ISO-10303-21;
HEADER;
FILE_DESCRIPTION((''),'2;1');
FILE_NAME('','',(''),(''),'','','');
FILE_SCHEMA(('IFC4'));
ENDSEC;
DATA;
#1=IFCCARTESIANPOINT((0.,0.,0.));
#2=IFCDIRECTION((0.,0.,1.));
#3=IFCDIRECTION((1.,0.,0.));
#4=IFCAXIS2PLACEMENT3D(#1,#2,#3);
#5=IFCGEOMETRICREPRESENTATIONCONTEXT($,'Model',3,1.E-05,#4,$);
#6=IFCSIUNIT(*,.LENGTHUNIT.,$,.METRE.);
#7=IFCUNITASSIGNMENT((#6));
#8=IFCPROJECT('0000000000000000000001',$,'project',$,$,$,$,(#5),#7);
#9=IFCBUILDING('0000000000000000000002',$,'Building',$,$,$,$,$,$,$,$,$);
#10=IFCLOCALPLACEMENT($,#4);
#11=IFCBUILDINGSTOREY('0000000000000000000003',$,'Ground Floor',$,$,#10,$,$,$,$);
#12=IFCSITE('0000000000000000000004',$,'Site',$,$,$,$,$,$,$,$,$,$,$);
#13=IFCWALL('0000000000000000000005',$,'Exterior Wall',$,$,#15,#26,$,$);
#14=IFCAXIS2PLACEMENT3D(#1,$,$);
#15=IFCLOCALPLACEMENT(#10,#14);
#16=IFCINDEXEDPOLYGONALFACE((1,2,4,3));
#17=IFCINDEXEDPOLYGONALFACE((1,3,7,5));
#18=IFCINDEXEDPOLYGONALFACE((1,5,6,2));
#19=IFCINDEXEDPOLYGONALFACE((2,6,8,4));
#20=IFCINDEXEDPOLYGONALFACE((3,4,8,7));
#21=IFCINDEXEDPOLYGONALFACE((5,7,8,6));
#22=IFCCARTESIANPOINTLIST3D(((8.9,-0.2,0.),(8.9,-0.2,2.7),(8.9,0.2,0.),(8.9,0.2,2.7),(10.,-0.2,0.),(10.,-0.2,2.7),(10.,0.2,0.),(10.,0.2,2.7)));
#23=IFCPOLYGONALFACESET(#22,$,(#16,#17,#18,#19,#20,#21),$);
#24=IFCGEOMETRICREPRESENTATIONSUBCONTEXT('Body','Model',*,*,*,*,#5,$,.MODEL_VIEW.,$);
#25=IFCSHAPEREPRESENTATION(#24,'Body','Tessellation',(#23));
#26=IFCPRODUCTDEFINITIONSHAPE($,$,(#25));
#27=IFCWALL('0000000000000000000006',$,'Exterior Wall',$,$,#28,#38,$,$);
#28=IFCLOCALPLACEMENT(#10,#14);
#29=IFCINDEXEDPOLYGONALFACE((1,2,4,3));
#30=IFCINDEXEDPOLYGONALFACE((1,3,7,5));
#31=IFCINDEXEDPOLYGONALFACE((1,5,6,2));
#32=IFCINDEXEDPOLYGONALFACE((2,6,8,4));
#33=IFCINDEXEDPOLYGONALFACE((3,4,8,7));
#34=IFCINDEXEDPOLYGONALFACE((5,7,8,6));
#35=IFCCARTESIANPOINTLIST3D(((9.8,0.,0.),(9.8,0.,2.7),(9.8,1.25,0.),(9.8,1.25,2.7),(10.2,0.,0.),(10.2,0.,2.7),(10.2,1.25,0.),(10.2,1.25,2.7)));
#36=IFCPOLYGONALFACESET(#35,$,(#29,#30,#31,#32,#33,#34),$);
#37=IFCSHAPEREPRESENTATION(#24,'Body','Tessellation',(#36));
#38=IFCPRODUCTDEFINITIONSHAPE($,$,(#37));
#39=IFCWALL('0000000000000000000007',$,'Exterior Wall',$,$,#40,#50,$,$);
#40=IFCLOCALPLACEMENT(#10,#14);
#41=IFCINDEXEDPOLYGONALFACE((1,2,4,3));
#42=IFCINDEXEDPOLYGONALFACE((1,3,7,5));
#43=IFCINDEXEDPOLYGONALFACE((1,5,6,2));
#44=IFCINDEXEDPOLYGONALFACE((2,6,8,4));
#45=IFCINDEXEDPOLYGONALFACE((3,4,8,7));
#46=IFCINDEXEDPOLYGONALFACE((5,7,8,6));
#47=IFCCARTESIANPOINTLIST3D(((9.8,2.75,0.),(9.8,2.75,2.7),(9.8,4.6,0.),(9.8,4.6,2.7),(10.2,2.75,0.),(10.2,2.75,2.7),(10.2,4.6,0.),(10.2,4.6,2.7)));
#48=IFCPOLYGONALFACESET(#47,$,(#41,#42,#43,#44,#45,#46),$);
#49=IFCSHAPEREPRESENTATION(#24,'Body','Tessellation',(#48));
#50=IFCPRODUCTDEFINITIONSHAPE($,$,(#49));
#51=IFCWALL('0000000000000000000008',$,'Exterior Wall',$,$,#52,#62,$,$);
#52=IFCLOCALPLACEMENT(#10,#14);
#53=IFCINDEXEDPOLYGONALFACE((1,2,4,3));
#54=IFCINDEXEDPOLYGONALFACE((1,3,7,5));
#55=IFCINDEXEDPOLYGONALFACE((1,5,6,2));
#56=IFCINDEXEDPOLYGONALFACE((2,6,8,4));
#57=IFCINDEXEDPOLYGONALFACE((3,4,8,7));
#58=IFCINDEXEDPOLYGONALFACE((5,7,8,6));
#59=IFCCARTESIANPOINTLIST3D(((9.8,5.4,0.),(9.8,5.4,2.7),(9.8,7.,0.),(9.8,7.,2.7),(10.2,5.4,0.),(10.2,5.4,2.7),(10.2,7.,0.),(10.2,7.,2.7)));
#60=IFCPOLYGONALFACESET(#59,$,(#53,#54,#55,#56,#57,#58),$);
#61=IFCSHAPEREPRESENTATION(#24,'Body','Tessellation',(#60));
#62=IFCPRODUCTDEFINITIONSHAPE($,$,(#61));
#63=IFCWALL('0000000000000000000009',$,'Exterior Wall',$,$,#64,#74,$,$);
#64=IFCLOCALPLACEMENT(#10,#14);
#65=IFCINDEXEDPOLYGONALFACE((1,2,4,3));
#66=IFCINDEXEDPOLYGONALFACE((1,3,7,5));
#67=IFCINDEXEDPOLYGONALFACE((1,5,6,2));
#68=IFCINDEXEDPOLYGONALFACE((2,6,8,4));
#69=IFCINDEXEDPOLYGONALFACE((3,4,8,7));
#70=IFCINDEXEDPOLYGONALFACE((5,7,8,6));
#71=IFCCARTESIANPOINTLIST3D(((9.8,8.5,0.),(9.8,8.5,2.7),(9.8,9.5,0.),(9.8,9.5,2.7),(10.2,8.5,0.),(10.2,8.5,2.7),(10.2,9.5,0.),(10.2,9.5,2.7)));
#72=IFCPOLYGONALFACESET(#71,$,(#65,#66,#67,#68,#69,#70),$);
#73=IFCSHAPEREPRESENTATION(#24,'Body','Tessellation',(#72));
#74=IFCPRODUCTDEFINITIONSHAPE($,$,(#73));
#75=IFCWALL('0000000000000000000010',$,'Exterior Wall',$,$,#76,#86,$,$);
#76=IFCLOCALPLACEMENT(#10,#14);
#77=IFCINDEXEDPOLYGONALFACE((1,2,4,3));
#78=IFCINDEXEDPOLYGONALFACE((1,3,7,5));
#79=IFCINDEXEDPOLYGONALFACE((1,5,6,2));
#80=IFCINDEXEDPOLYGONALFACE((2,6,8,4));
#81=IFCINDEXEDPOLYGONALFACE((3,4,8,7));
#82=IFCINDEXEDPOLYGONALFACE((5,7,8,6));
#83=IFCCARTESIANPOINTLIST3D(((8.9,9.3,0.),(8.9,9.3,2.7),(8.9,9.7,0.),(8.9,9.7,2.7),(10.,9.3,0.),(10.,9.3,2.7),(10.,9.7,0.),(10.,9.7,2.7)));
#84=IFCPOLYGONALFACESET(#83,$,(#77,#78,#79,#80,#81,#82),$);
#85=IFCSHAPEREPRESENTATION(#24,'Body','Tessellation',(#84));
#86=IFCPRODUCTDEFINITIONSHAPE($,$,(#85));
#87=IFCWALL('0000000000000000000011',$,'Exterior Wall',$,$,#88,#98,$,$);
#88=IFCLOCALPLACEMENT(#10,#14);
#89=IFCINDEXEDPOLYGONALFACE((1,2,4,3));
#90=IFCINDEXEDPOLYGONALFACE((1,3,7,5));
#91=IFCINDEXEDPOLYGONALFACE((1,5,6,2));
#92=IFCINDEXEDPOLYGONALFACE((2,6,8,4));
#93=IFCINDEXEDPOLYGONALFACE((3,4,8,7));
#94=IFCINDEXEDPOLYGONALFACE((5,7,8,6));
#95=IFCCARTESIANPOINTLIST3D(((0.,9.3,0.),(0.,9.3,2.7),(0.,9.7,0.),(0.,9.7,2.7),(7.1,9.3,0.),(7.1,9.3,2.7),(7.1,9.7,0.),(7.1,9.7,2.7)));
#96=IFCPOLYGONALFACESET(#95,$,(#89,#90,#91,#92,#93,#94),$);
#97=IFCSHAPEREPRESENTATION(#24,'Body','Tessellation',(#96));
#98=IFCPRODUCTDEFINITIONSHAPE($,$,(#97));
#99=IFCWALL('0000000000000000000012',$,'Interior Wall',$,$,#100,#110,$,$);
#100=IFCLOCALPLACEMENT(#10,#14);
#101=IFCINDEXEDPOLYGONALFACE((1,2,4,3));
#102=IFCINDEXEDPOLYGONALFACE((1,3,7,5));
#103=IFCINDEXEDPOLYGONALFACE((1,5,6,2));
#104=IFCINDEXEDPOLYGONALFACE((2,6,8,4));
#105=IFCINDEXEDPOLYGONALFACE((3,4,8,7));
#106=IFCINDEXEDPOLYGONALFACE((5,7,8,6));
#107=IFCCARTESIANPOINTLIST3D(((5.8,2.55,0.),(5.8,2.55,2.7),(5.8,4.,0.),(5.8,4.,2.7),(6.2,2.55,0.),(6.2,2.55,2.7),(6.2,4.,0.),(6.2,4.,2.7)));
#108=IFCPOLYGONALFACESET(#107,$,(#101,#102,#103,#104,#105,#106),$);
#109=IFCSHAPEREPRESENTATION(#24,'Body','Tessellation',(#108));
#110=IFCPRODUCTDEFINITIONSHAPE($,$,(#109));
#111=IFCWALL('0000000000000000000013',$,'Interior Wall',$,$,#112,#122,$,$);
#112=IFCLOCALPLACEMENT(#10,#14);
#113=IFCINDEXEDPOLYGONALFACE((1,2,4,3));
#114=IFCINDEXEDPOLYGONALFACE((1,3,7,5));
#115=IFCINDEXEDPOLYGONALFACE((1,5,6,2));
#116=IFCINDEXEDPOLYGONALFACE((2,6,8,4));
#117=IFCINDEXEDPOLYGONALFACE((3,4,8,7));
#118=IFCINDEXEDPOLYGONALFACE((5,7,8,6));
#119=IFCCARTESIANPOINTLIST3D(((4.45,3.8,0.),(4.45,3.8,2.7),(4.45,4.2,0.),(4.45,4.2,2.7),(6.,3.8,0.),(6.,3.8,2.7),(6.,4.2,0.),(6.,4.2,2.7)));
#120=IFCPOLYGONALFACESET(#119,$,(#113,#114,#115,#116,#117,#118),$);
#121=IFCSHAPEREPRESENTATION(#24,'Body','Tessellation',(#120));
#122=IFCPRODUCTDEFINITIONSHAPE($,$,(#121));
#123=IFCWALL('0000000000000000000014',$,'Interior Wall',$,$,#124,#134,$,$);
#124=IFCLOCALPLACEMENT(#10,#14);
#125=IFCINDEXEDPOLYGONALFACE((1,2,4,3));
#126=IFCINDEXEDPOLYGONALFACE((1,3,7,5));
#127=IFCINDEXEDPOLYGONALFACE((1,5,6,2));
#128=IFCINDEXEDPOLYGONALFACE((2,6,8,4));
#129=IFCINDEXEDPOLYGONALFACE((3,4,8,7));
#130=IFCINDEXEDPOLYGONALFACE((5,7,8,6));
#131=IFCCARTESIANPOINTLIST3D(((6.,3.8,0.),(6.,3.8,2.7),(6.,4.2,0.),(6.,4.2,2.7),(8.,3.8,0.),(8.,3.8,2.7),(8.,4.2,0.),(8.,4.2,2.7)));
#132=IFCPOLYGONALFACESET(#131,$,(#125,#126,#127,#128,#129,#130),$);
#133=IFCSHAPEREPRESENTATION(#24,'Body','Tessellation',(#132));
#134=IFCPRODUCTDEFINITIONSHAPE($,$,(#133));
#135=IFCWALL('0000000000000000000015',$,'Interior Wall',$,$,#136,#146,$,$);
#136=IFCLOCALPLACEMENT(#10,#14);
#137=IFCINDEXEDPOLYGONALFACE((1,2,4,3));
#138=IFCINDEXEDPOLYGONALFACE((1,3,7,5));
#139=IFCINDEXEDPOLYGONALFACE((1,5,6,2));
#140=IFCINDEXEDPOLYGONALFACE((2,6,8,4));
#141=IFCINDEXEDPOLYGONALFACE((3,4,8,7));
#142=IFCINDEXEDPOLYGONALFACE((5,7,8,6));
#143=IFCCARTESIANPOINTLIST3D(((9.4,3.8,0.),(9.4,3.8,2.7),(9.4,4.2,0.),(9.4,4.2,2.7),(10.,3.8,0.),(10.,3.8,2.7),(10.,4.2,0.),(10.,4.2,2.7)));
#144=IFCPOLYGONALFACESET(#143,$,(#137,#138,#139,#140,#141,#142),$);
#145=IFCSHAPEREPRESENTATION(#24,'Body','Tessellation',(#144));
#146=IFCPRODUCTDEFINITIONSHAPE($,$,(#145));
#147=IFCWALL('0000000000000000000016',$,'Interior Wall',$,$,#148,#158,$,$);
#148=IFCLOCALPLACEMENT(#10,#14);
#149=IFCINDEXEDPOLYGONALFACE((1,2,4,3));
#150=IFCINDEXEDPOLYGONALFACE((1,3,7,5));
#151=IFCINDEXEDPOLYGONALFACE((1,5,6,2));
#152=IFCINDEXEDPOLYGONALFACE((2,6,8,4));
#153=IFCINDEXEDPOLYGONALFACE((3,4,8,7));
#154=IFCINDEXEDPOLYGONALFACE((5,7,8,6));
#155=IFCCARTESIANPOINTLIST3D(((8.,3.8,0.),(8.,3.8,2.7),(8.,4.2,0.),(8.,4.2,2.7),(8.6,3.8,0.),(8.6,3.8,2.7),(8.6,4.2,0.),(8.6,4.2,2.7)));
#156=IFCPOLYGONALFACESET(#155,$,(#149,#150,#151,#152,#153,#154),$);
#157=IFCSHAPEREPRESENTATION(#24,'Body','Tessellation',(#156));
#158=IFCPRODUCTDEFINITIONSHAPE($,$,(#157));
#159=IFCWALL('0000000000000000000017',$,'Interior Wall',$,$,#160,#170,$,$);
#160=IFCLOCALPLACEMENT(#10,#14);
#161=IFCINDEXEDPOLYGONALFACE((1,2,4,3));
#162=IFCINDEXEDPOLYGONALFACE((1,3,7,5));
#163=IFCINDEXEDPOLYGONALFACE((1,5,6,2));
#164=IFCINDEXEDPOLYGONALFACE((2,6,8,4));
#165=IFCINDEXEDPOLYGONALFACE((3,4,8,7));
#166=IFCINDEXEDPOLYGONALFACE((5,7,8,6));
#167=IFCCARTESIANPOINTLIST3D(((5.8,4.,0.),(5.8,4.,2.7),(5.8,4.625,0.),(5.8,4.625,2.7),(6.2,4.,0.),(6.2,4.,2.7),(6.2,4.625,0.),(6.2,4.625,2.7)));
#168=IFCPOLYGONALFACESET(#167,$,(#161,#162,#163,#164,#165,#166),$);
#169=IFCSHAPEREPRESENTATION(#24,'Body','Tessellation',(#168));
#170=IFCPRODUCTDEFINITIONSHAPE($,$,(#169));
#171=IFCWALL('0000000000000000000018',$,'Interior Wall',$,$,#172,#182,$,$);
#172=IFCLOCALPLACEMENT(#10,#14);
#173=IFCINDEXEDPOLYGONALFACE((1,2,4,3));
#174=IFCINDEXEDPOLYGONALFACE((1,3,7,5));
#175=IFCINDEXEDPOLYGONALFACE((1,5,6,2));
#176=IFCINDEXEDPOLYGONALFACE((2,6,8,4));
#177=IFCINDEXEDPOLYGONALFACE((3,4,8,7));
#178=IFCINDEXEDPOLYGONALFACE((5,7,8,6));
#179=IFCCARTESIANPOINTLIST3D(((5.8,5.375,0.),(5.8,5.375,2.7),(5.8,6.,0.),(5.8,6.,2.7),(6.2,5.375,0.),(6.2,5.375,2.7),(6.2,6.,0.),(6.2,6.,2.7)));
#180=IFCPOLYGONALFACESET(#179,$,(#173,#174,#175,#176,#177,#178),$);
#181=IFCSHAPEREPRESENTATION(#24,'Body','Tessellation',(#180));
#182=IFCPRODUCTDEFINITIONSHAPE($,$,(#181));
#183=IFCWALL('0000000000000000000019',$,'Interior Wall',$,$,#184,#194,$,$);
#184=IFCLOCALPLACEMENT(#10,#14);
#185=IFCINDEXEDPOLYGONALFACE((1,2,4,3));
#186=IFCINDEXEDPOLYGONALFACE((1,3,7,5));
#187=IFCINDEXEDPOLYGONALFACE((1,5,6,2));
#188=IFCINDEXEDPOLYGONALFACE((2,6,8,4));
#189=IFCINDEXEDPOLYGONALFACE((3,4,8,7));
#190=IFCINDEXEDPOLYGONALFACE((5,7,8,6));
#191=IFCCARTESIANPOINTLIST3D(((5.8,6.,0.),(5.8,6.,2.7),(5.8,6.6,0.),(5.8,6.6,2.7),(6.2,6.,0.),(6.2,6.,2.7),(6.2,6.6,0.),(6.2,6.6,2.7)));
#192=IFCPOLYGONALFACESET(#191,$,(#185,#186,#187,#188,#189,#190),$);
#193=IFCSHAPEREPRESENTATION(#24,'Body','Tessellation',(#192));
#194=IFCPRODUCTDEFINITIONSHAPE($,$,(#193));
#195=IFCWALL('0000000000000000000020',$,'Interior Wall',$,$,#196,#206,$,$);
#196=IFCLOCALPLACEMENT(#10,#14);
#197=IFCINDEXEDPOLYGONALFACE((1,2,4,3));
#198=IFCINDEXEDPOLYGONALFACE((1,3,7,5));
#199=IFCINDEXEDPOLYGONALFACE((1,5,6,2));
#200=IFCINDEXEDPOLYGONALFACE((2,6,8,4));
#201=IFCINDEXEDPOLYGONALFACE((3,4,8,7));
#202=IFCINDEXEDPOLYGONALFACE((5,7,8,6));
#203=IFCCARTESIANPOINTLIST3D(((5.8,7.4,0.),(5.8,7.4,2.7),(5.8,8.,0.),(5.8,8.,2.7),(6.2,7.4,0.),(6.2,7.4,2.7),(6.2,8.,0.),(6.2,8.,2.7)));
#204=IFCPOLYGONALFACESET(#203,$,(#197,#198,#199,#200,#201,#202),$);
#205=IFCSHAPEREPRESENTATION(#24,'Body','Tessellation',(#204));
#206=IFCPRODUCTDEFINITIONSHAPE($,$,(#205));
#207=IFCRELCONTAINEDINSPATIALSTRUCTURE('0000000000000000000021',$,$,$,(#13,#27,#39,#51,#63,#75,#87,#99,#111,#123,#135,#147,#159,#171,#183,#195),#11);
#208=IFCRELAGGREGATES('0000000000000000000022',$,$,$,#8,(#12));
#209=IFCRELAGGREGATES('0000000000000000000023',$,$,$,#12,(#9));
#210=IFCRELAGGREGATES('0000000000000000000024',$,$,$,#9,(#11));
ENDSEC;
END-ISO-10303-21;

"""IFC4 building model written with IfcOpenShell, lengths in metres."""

from ifc_helpers import new_model, si_unit, frame, origin_with_axes, place, context, subcontext, project, spatial, indexed_curve, outline, extrude, element, save


model = new_model("IFC4")

# Units and contexts
model_context = context("Model", 3, precision=1e-05, world=origin_with_axes())
body_context = subcontext(model_context, "Body", "Model", "MODEL_VIEW")
ifc_project = project(units=[si_unit("LENGTHUNIT", "METRE")], contexts=[model_context])

# Site, building, storey
site = spatial("IfcSite", under=ifc_project, Name="Site")
building = spatial("IfcBuilding", under=site, Name="Building")
storey_placement = place(None, origin_with_axes())
storey = spatial("IfcBuildingStorey", under=building, at=storey_placement, Name="Ground Floor")

# Walls
wall_1_placement = place(storey_placement, frame((8.9, 0.0, 0.0), z_axis=(0.0, 0.0, 1.0), x_axis=(1.0, 0.0, 0.0)))
element("IfcWall", 1, at=wall_1_placement, inside=storey, Name="Exterior Wall", context=body_context, shape_type="SweptSolid", body=[
    extrude(outline(indexed_curve([(0.0, 0.0), (0.0, 0.4), (1.1, 0.4), (1.1, 0.0), (0.0, 0.0)], self_intersect=False)), frame((0.0, -0.2, 0.0), z_axis=(0.0, 0.0, 1.0), x_axis=(1.0, 0.0, 0.0)), (0.0, 0.0, 1.0), 2.7),
])
wall_2_placement = place(storey_placement, frame((10.0, 0.0, 0.0), z_axis=(0.0, 0.0, 1.0), x_axis=(0.0, 1.0, 0.0)))
element("IfcWall", 2, at=wall_2_placement, inside=storey, Name="Exterior Wall", context=body_context, shape_type="SweptSolid", body=[
    extrude(outline(indexed_curve([(0.0, 0.0), (0.0, 0.4), (1.25, 0.4), (1.25, 0.0), (0.0, 0.0)], self_intersect=False)), frame((0.0, -0.2, 0.0), z_axis=(0.0, 0.0, 1.0), x_axis=(1.0, 0.0, 0.0)), (0.0, 0.0, 1.0), 2.7),
])
wall_3_placement = place(storey_placement, frame((10.0, 2.75, 0.0), z_axis=(0.0, 0.0, 1.0), x_axis=(0.0, 1.0, 0.0)))
element("IfcWall", 3, at=wall_3_placement, inside=storey, Name="Exterior Wall", context=body_context, shape_type="SweptSolid", body=[
    extrude(outline(indexed_curve([(0.0, 0.0), (0.0, 0.4), (1.85, 0.4), (1.85, 0.0), (0.0, 0.0)], self_intersect=False)), frame((0.0, -0.2, 0.0), z_axis=(0.0, 0.0, 1.0), x_axis=(1.0, 0.0, 0.0)), (0.0, 0.0, 1.0), 2.7),
])
wall_4_placement = place(storey_placement, frame((10.0, 5.4, 0.0), z_axis=(0.0, 0.0, 1.0), x_axis=(0.0, 1.0, 0.0)))
element("IfcWall", 4, at=wall_4_placement, inside=storey, Name="Exterior Wall", context=body_context, shape_type="SweptSolid", body=[
    extrude(outline(indexed_curve([(0.0, 0.0), (0.0, 0.4), (1.6, 0.4), (1.6, 0.0), (0.0, 0.0)], self_intersect=False)), frame((0.0, -0.2, 0.0), z_axis=(0.0, 0.0, 1.0), x_axis=(1.0, 0.0, 0.0)), (0.0, 0.0, 1.0), 2.7),
])
wall_5_placement = place(storey_placement, frame((10.0, 8.5, 0.0), z_axis=(0.0, 0.0, 1.0), x_axis=(0.0, 1.0, 0.0)))
element("IfcWall", 5, at=wall_5_placement, inside=storey, Name="Exterior Wall", context=body_context, shape_type="SweptSolid", body=[
    extrude(outline(indexed_curve([(0.0, 0.0), (0.0, 0.4), (1.0, 0.4), (1.0, 0.0), (0.0, 0.0)], self_intersect=False)), frame((0.0, -0.2, 0.0), z_axis=(0.0, 0.0, 1.0), x_axis=(1.0, 0.0, 0.0)), (0.0, 0.0, 1.0), 2.7),
])
wall_6_placement = place(storey_placement, frame((10.0, 9.5, 0.0), z_axis=(0.0, 0.0, 1.0), x_axis=(-1.0, 0.0, 0.0)))
element("IfcWall", 6, at=wall_6_placement, inside=storey, Name="Exterior Wall", context=body_context, shape_type="SweptSolid", body=[
    extrude(outline(indexed_curve([(0.0, 0.0), (0.0, 0.4), (1.1, 0.4), (1.1, 0.0), (0.0, 0.0)], self_intersect=False)), frame((0.0, -0.2, 0.0), z_axis=(0.0, 0.0, 1.0), x_axis=(1.0, 0.0, 0.0)), (0.0, 0.0, 1.0), 2.7),
])
wall_7_placement = place(storey_placement, frame((7.1, 9.5, 0.0), z_axis=(0.0, 0.0, 1.0), x_axis=(-1.0, 0.0, 0.0)))
element("IfcWall", 7, at=wall_7_placement, inside=storey, Name="Exterior Wall", context=body_context, shape_type="SweptSolid", body=[
    extrude(outline(indexed_curve([(0.0, 0.0), (0.0, 0.4), (7.1, 0.4), (7.1, 0.0), (0.0, 0.0)], self_intersect=False)), frame((0.0, -0.2, 0.0), z_axis=(0.0, 0.0, 1.0), x_axis=(1.0, 0.0, 0.0)), (0.0, 0.0, 1.0), 2.7),
])
wall_8_placement = place(storey_placement, frame((6.0, 2.55, 0.0), z_axis=(0.0, 0.0, 1.0), x_axis=(0.0, 1.0, 0.0)))
element("IfcWall", 8, at=wall_8_placement, inside=storey, Name="Interior Wall", context=body_context, shape_type="SweptSolid", body=[
    extrude(outline(indexed_curve([(0.0, 0.0), (0.0, 0.4), (1.45, 0.4), (1.45, 0.0), (0.0, 0.0)], self_intersect=False)), frame((0.0, -0.2, 0.0), z_axis=(0.0, 0.0, 1.0), x_axis=(1.0, 0.0, 0.0)), (0.0, 0.0, 1.0), 2.7),
])
wall_9_placement = place(storey_placement, frame((6.0, 4.0, 0.0), z_axis=(0.0, 0.0, 1.0), x_axis=(-1.0, 0.0, 0.0)))
element("IfcWall", 9, at=wall_9_placement, inside=storey, Name="Interior Wall", context=body_context, shape_type="SweptSolid", body=[
    extrude(outline(indexed_curve([(0.0, 0.0), (0.0, 0.4), (1.55, 0.4), (1.55, 0.0), (0.0, 0.0)], self_intersect=False)), frame((0.0, -0.2, 0.0), z_axis=(0.0, 0.0, 1.0), x_axis=(1.0, 0.0, 0.0)), (0.0, 0.0, 1.0), 2.7),
])
wall_10_placement = place(storey_placement, frame((8.0, 4.0, 0.0), z_axis=(0.0, 0.0, 1.0), x_axis=(-1.0, 0.0, 0.0)))
element("IfcWall", 10, at=wall_10_placement, inside=storey, Name="Interior Wall", context=body_context, shape_type="SweptSolid", body=[
    extrude(outline(indexed_curve([(0.0, 0.0), (0.0, 0.4), (2.0, 0.4), (2.0, 0.0), (0.0, 0.0)], self_intersect=False)), frame((0.0, -0.2, 0.0), z_axis=(0.0, 0.0, 1.0), x_axis=(1.0, 0.0, 0.0)), (0.0, 0.0, 1.0), 2.7),
])
for number, where, z_axis, x_axis, name in (
    (11, (10.0, 4.0, 0.0), (0.0, 0.0, 1.0), (-1.0, 0.0, 0.0), "Interior Wall"),
    (12, (8.6, 4.0, 0.0), (0.0, 0.0, 1.0), (-1.0, 0.0, 0.0), "Interior Wall"),
):
    element("IfcWall", number, at=place(storey_placement, frame(where, z_axis=z_axis, x_axis=x_axis)), inside=storey, Name=name, context=body_context, shape_type="SweptSolid", body=[
        extrude(outline(indexed_curve([(0.0, 0.0), (0.0, 0.4), (0.6, 0.4), (0.6, 0.0), (0.0, 0.0)], self_intersect=False)), frame((0.0, -0.2, 0.0), z_axis=(0.0, 0.0, 1.0), x_axis=(1.0, 0.0, 0.0)), (0.0, 0.0, 1.0), 2.7),
    ])
for number, where, z_axis, x_axis, name in (
    (13, (6.0, 4.0, 0.0), (0.0, 0.0, 1.0), (0.0, 1.0, 0.0), "Interior Wall"),
    (14, (6.0, 5.375, 0.0), (0.0, 0.0, 1.0), (0.0, 1.0, 0.0), "Interior Wall"),
):
    element("IfcWall", number, at=place(storey_placement, frame(where, z_axis=z_axis, x_axis=x_axis)), inside=storey, Name=name, context=body_context, shape_type="SweptSolid", body=[
        extrude(outline(indexed_curve([(0.0, 0.0), (0.0, 0.4), (0.625, 0.4), (0.625, 0.0), (0.0, 0.0)], self_intersect=False)), frame((0.0, -0.2, 0.0), z_axis=(0.0, 0.0, 1.0), x_axis=(1.0, 0.0, 0.0)), (0.0, 0.0, 1.0), 2.7),
    ])
for number, where, z_axis, x_axis, name in (
    (15, (6.0, 6.0, 0.0), (0.0, 0.0, 1.0), (0.0, 1.0, 0.0), "Interior Wall"),
    (16, (6.0, 7.4, 0.0), (0.0, 0.0, 1.0), (0.0, 1.0, 0.0), "Interior Wall"),
):
    element("IfcWall", number, at=place(storey_placement, frame(where, z_axis=z_axis, x_axis=x_axis)), inside=storey, Name=name, context=body_context, shape_type="SweptSolid", body=[
        extrude(outline(indexed_curve([(0.0, 0.0), (0.0, 0.4), (0.6, 0.4), (0.6, 0.0), (0.0, 0.0)], self_intersect=False)), frame((0.0, -0.2, 0.0), z_axis=(0.0, 0.0, 1.0), x_axis=(1.0, 0.0, 0.0)), (0.0, 0.0, 1.0), 2.7),
    ])

save(model, "model.ifc")
